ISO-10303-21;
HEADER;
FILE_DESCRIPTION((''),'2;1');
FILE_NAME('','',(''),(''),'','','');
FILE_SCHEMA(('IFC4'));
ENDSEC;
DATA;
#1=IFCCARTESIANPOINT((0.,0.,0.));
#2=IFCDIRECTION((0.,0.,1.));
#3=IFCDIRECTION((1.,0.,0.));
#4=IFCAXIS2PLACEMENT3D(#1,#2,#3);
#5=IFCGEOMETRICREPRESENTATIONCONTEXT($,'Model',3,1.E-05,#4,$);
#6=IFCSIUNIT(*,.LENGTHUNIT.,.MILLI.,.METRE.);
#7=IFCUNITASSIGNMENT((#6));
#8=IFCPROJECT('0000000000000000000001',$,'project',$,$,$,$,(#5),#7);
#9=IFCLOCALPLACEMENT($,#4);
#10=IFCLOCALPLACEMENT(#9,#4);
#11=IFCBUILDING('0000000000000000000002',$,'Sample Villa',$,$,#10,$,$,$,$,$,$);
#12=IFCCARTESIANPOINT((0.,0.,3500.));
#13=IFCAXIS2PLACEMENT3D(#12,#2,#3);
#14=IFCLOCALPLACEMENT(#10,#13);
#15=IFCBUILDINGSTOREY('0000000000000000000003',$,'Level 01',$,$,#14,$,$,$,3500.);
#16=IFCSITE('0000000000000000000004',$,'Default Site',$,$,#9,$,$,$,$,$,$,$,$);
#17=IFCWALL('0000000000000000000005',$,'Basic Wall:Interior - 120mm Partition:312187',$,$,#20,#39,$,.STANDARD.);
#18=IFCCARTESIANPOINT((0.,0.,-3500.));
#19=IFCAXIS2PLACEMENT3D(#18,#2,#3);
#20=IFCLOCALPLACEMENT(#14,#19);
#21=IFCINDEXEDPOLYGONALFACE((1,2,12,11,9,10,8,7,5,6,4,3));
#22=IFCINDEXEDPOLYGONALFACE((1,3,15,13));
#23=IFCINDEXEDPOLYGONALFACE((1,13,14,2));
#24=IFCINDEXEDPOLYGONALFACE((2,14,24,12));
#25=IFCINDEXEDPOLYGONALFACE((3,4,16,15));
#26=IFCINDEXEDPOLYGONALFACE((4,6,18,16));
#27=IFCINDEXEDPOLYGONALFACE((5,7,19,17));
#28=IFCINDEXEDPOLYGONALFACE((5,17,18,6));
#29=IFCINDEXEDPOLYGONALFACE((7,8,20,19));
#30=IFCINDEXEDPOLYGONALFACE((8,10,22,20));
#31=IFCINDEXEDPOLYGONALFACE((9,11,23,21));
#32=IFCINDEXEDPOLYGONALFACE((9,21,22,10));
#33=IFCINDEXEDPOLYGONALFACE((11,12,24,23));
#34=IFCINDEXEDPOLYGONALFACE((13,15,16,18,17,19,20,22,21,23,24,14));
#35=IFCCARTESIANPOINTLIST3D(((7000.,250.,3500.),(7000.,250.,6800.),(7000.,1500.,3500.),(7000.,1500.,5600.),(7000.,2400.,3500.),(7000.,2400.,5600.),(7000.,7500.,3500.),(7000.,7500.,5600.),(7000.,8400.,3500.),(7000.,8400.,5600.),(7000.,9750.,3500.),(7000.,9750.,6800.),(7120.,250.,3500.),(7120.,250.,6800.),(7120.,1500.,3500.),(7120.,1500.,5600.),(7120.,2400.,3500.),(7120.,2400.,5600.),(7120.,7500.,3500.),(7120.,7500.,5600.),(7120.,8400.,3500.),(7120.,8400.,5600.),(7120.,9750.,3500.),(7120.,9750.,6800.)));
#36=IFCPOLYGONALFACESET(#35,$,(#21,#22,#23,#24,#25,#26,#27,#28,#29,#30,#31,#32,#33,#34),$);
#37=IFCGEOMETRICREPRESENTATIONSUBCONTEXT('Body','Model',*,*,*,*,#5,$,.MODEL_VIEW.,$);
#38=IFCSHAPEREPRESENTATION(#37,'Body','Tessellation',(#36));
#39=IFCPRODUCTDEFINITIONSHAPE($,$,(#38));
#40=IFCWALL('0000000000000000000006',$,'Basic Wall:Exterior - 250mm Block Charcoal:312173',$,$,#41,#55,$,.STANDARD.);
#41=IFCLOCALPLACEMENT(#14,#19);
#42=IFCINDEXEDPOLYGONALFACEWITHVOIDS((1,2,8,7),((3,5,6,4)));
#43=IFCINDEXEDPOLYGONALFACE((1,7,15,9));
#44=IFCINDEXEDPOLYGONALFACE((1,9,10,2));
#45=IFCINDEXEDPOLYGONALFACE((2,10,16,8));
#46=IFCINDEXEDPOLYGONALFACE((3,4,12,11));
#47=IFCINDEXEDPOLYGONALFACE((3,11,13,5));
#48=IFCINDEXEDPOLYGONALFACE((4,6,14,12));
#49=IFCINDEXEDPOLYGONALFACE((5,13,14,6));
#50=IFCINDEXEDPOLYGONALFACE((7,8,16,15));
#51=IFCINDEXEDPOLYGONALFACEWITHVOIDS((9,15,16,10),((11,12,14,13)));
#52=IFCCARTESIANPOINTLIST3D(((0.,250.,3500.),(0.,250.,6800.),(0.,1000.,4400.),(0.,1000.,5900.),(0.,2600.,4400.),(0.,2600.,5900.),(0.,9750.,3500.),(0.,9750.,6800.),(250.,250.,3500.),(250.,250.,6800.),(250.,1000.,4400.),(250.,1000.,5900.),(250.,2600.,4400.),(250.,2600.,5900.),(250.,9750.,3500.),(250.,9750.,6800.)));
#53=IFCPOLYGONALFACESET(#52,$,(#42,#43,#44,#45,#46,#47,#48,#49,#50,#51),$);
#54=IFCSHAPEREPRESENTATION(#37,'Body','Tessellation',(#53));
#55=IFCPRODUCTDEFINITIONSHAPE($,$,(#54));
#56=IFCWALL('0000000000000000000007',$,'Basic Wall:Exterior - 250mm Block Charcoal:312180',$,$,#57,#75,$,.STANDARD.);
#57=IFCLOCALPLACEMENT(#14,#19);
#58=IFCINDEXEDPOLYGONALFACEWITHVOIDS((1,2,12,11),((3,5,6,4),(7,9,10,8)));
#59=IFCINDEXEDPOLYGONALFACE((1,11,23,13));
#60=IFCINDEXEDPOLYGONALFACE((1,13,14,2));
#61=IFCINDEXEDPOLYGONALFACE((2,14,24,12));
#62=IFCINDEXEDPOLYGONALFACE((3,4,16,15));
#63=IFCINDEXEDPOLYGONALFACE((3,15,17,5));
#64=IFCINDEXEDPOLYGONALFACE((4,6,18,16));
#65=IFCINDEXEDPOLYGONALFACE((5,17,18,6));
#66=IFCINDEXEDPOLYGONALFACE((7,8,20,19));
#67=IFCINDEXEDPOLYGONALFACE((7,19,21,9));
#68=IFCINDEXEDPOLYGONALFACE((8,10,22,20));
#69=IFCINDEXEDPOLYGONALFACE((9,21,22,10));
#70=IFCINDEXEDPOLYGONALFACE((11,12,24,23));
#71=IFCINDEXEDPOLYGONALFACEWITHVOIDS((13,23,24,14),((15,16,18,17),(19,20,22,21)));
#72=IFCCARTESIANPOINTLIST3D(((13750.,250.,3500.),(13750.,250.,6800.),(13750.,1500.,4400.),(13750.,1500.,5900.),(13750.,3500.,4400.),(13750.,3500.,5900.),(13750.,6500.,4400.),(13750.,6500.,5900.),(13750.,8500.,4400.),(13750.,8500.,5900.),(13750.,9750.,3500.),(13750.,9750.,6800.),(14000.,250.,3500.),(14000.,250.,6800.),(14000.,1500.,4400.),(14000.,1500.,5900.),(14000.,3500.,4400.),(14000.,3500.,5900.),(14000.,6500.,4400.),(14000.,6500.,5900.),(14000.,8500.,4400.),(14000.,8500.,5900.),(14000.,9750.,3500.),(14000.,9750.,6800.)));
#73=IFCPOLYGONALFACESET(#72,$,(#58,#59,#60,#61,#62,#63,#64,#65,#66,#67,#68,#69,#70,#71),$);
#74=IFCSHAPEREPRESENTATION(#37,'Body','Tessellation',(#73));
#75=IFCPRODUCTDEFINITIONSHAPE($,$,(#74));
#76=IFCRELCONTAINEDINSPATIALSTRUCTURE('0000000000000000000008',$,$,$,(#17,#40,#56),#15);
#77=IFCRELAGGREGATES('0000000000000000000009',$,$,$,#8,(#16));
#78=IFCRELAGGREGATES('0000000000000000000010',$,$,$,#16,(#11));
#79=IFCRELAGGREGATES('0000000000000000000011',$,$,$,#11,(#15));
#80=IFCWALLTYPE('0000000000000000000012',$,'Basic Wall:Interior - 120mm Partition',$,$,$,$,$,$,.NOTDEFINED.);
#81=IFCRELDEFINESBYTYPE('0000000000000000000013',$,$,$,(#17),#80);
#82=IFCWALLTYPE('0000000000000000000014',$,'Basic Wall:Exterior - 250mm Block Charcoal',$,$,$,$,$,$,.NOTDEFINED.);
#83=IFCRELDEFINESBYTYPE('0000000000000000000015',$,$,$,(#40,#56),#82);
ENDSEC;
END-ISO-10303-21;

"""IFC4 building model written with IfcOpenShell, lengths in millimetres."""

from ifc_helpers import new_model, si_unit, frame, frame_2d, origin_with_axes, place, context, subcontext, project, spatial, rectangle, extrude, type_object, element, save


model = new_model("IFC4")

# Units and contexts
model_context = context("Model", 3, precision=1e-05, world=origin_with_axes())
body_context = subcontext(model_context, "Body", "Model", "MODEL_VIEW")
ifc_project = project(units=[si_unit("LENGTHUNIT", "METRE", prefix="MILLI")], contexts=[model_context])

# Site, building, storey
site_placement = place(None, origin_with_axes())
site = spatial("IfcSite", under=ifc_project, at=site_placement, Name="Default Site")
building_placement = place(site_placement, origin_with_axes())
building = spatial("IfcBuilding", under=site, at=building_placement, Name="Sample Villa")
storey_placement = place(building_placement, frame((0.0, 0.0, 3500.0), z_axis=(0.0, 0.0, 1.0), x_axis=(1.0, 0.0, 0.0)))
storey = spatial("IfcBuildingStorey", under=building, at=storey_placement, Name="Level 01", Elevation=3500.0)

# Wall, openings
wall_type_1 = type_object("IfcWallType", Name="Basic Wall:Interior - 120mm Partition", PredefinedType="NOTDEFINED")
wall_1_placement = place(storey_placement, frame((0.0, 0.0, -3500.0), z_axis=(0.0, 0.0, 1.0), x_axis=(1.0, 0.0, 0.0)))
wall_1 = element("IfcWall", 1, at=wall_1_placement, inside=storey, type_object=wall_type_1, Name="Basic Wall:Interior - 120mm Partition:312187", PredefinedType="STANDARD", context=body_context, shape_type="SweptSolid", body=[
    extrude(rectangle(XDim=120.0, YDim=9500.0, at=frame_2d((60.0, 4750.0))), frame((7000.0, 250.0, 3500.0)), (0.0, 0.0, 1.0), 3300.0),
])
opening_1_placement = place(wall_1_placement, origin_with_axes())
element("IfcOpeningElement", 2, at=opening_1_placement, cuts=wall_1, context=body_context, shape_type="SweptSolid", body=[
    extrude(rectangle(XDim=220.0, YDim=900.0, at=frame_2d((110.0, 450.0))), frame((6950.0, 1500.0, 3500.0)), (0.0, 0.0, 1.0), 2100.0),
])
opening_2_placement = place(wall_1_placement, origin_with_axes())
element("IfcOpeningElement", 3, at=opening_2_placement, cuts=wall_1, context=body_context, shape_type="SweptSolid", body=[
    extrude(rectangle(XDim=220.0, YDim=900.0, at=frame_2d((110.0, 450.0))), frame((6950.0, 7500.0, 3500.0)), (0.0, 0.0, 1.0), 2100.0),
])

# Shared definitions
wall_type_2 = type_object("IfcWallType", Name="Basic Wall:Exterior - 250mm Block Charcoal", PredefinedType="NOTDEFINED")

# Wall, opening
wall_2_placement = place(storey_placement, frame((0.0, 0.0, -3500.0), z_axis=(0.0, 0.0, 1.0), x_axis=(1.0, 0.0, 0.0)))
wall_2 = element("IfcWall", 4, at=wall_2_placement, inside=storey, type_object=wall_type_2, Name="Basic Wall:Exterior - 250mm Block Charcoal:312173", PredefinedType="STANDARD", context=body_context, shape_type="SweptSolid", body=[
    extrude(rectangle(XDim=250.0, YDim=9500.0, at=frame_2d((125.0, 4750.0))), frame((0.0, 250.0, 3500.0)), (0.0, 0.0, 1.0), 3300.0),
])
opening_3_placement = place(wall_2_placement, origin_with_axes())
element("IfcOpeningElement", 5, at=opening_3_placement, cuts=wall_2, context=body_context, shape_type="SweptSolid", body=[
    extrude(rectangle(XDim=350.0, YDim=1600.0, at=frame_2d((175.0, 800.0))), frame((-50.0, 1000.0, 4400.0)), (0.0, 0.0, 1.0), 1500.0),
])

# Wall, openings
wall_3_placement = place(storey_placement, frame((0.0, 0.0, -3500.0), z_axis=(0.0, 0.0, 1.0), x_axis=(1.0, 0.0, 0.0)))
wall_3 = element("IfcWall", 6, at=wall_3_placement, inside=storey, type_object=wall_type_2, Name="Basic Wall:Exterior - 250mm Block Charcoal:312180", PredefinedType="STANDARD", context=body_context, shape_type="SweptSolid", body=[
    extrude(rectangle(XDim=250.0, YDim=9500.0, at=frame_2d((125.0, 4750.0))), frame((13750.0, 250.0, 3500.0)), (0.0, 0.0, 1.0), 3300.0),
])
opening_4_placement = place(wall_3_placement, origin_with_axes())
element("IfcOpeningElement", 7, at=opening_4_placement, cuts=wall_3, context=body_context, shape_type="SweptSolid", body=[
    extrude(rectangle(XDim=350.0, YDim=2000.0, at=frame_2d((175.0, 1000.0))), frame((13700.0, 1500.0, 4400.0)), (0.0, 0.0, 1.0), 1500.0),
])
opening_5_placement = place(wall_3_placement, origin_with_axes())
element("IfcOpeningElement", 8, at=opening_5_placement, cuts=wall_3, context=body_context, shape_type="SweptSolid", body=[
    extrude(rectangle(XDim=350.0, YDim=2000.0, at=frame_2d((175.0, 1000.0))), frame((13700.0, 6500.0, 4400.0)), (0.0, 0.0, 1.0), 1500.0),
])

save(model, "model.ifc")
